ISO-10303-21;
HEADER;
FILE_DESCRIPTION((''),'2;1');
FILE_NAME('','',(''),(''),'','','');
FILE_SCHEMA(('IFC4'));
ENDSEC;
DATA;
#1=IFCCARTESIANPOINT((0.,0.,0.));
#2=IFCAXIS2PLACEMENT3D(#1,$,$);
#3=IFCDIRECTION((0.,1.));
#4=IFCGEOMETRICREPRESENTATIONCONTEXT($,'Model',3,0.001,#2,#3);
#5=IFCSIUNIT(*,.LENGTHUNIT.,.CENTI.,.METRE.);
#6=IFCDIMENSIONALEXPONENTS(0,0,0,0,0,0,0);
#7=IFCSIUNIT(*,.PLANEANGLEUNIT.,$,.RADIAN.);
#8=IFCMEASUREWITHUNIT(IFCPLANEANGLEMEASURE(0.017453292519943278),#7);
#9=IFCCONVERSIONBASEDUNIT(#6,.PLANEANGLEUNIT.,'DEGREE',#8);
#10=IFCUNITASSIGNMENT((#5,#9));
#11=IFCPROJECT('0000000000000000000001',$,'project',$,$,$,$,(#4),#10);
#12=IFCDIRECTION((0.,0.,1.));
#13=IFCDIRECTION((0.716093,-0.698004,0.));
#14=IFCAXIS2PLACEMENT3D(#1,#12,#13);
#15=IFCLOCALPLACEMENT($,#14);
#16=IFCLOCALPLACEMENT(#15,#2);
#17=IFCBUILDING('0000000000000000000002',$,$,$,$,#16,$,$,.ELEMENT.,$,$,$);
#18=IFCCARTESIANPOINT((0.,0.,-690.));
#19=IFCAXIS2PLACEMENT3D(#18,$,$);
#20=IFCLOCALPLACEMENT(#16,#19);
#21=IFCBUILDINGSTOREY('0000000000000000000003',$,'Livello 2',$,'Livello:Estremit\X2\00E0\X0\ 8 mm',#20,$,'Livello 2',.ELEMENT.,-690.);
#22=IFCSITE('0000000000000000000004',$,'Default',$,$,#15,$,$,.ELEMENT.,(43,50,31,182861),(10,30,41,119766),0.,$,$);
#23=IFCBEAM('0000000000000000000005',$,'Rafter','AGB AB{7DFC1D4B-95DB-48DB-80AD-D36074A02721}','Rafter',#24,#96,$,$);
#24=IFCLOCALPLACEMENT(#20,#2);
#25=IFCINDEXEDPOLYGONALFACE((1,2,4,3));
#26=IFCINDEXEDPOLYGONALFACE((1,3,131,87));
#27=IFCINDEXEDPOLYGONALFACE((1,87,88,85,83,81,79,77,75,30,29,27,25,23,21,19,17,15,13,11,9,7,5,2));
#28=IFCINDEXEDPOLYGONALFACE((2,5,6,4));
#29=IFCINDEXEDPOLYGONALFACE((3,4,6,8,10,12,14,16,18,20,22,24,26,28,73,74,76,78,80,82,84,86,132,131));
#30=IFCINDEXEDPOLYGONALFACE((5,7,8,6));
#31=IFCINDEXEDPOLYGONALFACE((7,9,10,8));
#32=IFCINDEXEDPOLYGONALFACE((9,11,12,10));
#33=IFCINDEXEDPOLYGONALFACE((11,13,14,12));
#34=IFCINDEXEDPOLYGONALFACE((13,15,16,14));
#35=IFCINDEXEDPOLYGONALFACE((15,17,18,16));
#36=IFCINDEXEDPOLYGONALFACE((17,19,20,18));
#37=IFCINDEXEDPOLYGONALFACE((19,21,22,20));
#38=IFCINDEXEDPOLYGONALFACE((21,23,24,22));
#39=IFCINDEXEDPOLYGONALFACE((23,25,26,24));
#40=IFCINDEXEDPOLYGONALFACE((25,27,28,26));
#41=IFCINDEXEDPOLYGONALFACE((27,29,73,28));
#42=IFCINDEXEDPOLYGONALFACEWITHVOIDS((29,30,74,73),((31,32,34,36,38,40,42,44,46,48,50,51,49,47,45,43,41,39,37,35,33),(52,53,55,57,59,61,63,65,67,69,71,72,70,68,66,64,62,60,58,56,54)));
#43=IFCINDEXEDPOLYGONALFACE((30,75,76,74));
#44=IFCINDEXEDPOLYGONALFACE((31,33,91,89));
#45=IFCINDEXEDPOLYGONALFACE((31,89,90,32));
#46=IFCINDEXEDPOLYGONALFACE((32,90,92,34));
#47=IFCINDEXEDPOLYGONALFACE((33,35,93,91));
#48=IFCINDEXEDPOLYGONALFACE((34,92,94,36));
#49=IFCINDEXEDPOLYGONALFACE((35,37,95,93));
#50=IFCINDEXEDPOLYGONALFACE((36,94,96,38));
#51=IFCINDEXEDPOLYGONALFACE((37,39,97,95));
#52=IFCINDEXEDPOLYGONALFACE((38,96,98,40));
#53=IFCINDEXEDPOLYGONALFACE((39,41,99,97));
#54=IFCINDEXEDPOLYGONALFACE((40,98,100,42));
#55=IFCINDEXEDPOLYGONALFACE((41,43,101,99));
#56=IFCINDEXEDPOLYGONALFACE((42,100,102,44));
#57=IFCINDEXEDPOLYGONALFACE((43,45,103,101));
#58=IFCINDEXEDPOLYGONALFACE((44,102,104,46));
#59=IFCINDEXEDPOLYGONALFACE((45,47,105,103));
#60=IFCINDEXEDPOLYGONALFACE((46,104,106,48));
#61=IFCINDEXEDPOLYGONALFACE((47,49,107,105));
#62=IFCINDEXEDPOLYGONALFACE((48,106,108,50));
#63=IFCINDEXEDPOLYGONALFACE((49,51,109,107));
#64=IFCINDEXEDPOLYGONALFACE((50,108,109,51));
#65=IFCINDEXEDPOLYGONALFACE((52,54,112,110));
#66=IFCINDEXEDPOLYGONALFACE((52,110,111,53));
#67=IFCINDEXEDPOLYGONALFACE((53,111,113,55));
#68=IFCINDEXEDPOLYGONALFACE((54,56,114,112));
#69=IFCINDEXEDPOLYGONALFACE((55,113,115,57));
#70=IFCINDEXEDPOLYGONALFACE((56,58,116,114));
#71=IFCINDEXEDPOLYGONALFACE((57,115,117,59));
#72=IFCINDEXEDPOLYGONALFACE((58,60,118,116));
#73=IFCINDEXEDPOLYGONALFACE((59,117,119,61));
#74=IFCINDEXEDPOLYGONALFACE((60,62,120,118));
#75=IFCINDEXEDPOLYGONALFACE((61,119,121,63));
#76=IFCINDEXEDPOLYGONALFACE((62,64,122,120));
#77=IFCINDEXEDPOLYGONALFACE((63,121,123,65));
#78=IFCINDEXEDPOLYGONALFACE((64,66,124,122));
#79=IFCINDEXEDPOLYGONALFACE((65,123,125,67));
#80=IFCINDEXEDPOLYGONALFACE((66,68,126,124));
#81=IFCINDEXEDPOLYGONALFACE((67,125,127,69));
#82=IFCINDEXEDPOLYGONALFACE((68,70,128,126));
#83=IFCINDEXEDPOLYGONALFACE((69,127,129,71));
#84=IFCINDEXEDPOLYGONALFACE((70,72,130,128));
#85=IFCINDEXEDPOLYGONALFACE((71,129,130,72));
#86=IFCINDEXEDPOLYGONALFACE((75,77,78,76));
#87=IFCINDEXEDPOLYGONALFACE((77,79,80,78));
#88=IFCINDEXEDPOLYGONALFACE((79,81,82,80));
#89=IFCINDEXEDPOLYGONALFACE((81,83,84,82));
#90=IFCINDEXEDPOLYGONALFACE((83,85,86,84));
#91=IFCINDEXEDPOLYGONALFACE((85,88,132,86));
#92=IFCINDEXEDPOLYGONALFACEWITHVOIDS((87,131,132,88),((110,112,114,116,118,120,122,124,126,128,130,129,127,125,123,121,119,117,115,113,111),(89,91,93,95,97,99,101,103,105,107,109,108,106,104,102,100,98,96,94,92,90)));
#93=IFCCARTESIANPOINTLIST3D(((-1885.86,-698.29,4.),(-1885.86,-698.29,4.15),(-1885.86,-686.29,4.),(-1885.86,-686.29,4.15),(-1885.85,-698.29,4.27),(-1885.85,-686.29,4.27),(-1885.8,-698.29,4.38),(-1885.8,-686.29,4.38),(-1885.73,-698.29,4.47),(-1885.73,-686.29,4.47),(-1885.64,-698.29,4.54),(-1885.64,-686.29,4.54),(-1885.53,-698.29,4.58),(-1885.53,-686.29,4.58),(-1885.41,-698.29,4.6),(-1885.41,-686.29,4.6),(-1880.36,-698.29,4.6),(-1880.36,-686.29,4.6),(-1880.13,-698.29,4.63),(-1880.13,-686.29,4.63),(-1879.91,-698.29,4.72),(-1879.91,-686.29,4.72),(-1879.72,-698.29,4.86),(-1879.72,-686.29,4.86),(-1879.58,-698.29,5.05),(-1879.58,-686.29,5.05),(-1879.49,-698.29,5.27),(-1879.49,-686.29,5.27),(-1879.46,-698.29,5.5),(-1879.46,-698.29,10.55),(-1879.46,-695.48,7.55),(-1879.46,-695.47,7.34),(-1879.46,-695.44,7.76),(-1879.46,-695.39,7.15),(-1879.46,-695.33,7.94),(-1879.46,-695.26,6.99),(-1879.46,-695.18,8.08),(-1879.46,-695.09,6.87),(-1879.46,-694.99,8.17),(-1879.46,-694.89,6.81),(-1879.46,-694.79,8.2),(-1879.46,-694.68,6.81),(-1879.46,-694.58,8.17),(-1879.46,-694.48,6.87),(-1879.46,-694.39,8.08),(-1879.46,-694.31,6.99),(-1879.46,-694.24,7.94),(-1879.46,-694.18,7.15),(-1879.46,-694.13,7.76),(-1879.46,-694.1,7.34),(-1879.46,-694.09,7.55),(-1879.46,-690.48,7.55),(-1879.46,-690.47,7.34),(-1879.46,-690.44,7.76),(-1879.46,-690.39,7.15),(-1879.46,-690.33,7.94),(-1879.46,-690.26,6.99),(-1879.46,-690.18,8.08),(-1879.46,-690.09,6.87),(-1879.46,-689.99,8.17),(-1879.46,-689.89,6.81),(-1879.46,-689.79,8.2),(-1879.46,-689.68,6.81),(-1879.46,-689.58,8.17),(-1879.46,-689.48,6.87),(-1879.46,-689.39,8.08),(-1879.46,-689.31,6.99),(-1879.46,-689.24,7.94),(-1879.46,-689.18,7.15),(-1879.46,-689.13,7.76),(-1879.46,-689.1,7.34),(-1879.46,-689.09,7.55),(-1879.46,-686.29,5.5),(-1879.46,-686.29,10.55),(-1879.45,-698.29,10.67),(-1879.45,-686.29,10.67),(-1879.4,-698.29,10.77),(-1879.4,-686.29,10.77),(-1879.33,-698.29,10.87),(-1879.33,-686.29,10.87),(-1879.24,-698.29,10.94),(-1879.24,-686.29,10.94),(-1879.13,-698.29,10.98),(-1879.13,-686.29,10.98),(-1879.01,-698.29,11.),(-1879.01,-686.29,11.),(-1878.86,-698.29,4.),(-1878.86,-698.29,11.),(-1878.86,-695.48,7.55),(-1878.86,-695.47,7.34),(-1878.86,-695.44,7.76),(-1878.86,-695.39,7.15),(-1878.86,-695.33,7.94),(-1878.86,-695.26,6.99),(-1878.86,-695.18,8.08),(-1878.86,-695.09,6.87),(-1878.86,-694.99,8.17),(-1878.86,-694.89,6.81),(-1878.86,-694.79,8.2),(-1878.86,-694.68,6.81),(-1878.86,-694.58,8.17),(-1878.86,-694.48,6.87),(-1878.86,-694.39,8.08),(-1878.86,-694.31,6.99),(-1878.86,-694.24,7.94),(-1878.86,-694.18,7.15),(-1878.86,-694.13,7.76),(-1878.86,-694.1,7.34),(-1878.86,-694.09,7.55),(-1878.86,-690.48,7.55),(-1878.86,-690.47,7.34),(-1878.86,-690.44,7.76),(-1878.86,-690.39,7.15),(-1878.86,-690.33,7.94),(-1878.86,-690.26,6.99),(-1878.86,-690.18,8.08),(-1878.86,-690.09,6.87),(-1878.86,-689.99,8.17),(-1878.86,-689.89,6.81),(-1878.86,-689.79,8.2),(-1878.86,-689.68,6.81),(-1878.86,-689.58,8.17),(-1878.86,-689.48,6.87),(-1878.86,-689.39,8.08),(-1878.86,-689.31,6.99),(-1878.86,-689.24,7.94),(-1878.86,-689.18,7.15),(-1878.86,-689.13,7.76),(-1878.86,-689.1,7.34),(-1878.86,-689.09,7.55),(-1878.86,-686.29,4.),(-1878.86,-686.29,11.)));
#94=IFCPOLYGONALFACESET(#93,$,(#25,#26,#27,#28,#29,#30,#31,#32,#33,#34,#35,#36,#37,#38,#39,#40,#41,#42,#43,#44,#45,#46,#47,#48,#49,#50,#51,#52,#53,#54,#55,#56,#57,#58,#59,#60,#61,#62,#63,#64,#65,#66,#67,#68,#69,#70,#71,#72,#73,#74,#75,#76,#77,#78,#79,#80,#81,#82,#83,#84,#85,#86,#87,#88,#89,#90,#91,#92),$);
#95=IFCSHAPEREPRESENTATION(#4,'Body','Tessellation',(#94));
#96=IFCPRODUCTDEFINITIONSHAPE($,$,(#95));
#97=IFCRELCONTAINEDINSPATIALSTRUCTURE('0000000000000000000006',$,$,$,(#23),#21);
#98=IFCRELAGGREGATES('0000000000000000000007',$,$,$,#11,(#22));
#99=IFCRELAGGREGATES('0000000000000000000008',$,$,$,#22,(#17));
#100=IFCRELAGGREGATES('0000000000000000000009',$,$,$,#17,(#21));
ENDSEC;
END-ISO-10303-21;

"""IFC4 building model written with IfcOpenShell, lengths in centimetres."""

from ifc_helpers import new_model, entity, si_unit, converted_unit, direction, frame, frame_2d, origin, place, context, project, spatial, circle, l_section, extrude, element, save


model = new_model("IFC4")

# Units and contexts
model_context = context("Model", 3, precision=0.001, world=origin(), true_north=direction((0.0, 1.0)))
ifc_project = project(units=[si_unit("LENGTHUNIT", "METRE", prefix="CENTI"), converted_unit("PLANEANGLEUNIT", "DEGREE", entity("IfcPlaneAngleMeasure", 0.017453292519943278), si_unit("PLANEANGLEUNIT", "RADIAN"), dimensions=[0, 0, 0, 0, 0, 0, 0])], contexts=[model_context])

# Site, building, storey
site_placement = place(None, frame((0.0, 0.0, 0.0), z_axis=(0.0, 0.0, 1.0), x_axis=(0.716093, -0.698004, 0.0)))
site = spatial("IfcSite", under=ifc_project, at=site_placement, Name="Default", CompositionType="ELEMENT", RefLatitude=(43, 50, 31, 182861), RefLongitude=(10, 30, 41, 119766), RefElevation=0.0)
building_placement = place(site_placement, origin())
building = spatial("IfcBuilding", under=site, at=building_placement, CompositionType="ELEMENT")
storey_placement = place(building_placement, frame((0.0, 0.0, -690.0)))
storey = spatial("IfcBuildingStorey", under=building, at=storey_placement, Name="Livello 2", ObjectType="Livello:Estremità 8 mm", LongName="Livello 2", CompositionType="ELEMENT", Elevation=-690.0)

# Beam, openings
beam_1_placement = place(storey_placement, frame((-1880.79, -686.29, 5.93), z_axis=(0.0, 1.0, 0.0), x_axis=(-1.0, 0.0, 0.0)))
beam_1 = element("IfcBeam", 1, at=beam_1_placement, inside=storey, Name="Rafter", Description="AGB AB{7DFC1D4B-95DB-48DB-80AD-D36074A02721}", ObjectType="Rafter", context=model_context, shape_type="SweptSolid", body=[
    extrude(l_section(Depth=7.0, Width=7.0, Thickness=0.6, FilletRadius=0.9, EdgeRadius=0.45, at=frame_2d((1.57, 1.57))), origin(), (0.0, 0.0, -1.0), 12.0),
])
opening_1_placement = place(beam_1_placement, frame((-1.28, 1.57, -7.8), z_axis=(1.0, 0.0, 0.0), x_axis=(0.0, 1.0, 0.0)))
element("IfcOpeningElement", 2, at=opening_1_placement, cuts=beam_1, ObjectType="Opening", context=model_context, shape_type="SweptSolid", body=[
    extrude(circle(Radius=0.7, at=frame_2d((0.0, -0.7), x_axis=(1.0, 0.0))), origin(), (0.0, 0.0, -1.0), 0.7),
])
opening_2_placement = place(beam_1_placement, frame((-1.28, 1.57, -2.8), z_axis=(1.0, 0.0, 0.0), x_axis=(0.0, 1.0, 0.0)))
element("IfcOpeningElement", 3, at=opening_2_placement, cuts=beam_1, ObjectType="Opening", context=model_context, shape_type="SweptSolid", body=[
    extrude(circle(Radius=0.7, at=frame_2d((0.0, -0.7), x_axis=(1.0, 0.0))), origin(), (0.0, 0.0, -1.0), 0.7),
])

save(model, "model.ifc")
